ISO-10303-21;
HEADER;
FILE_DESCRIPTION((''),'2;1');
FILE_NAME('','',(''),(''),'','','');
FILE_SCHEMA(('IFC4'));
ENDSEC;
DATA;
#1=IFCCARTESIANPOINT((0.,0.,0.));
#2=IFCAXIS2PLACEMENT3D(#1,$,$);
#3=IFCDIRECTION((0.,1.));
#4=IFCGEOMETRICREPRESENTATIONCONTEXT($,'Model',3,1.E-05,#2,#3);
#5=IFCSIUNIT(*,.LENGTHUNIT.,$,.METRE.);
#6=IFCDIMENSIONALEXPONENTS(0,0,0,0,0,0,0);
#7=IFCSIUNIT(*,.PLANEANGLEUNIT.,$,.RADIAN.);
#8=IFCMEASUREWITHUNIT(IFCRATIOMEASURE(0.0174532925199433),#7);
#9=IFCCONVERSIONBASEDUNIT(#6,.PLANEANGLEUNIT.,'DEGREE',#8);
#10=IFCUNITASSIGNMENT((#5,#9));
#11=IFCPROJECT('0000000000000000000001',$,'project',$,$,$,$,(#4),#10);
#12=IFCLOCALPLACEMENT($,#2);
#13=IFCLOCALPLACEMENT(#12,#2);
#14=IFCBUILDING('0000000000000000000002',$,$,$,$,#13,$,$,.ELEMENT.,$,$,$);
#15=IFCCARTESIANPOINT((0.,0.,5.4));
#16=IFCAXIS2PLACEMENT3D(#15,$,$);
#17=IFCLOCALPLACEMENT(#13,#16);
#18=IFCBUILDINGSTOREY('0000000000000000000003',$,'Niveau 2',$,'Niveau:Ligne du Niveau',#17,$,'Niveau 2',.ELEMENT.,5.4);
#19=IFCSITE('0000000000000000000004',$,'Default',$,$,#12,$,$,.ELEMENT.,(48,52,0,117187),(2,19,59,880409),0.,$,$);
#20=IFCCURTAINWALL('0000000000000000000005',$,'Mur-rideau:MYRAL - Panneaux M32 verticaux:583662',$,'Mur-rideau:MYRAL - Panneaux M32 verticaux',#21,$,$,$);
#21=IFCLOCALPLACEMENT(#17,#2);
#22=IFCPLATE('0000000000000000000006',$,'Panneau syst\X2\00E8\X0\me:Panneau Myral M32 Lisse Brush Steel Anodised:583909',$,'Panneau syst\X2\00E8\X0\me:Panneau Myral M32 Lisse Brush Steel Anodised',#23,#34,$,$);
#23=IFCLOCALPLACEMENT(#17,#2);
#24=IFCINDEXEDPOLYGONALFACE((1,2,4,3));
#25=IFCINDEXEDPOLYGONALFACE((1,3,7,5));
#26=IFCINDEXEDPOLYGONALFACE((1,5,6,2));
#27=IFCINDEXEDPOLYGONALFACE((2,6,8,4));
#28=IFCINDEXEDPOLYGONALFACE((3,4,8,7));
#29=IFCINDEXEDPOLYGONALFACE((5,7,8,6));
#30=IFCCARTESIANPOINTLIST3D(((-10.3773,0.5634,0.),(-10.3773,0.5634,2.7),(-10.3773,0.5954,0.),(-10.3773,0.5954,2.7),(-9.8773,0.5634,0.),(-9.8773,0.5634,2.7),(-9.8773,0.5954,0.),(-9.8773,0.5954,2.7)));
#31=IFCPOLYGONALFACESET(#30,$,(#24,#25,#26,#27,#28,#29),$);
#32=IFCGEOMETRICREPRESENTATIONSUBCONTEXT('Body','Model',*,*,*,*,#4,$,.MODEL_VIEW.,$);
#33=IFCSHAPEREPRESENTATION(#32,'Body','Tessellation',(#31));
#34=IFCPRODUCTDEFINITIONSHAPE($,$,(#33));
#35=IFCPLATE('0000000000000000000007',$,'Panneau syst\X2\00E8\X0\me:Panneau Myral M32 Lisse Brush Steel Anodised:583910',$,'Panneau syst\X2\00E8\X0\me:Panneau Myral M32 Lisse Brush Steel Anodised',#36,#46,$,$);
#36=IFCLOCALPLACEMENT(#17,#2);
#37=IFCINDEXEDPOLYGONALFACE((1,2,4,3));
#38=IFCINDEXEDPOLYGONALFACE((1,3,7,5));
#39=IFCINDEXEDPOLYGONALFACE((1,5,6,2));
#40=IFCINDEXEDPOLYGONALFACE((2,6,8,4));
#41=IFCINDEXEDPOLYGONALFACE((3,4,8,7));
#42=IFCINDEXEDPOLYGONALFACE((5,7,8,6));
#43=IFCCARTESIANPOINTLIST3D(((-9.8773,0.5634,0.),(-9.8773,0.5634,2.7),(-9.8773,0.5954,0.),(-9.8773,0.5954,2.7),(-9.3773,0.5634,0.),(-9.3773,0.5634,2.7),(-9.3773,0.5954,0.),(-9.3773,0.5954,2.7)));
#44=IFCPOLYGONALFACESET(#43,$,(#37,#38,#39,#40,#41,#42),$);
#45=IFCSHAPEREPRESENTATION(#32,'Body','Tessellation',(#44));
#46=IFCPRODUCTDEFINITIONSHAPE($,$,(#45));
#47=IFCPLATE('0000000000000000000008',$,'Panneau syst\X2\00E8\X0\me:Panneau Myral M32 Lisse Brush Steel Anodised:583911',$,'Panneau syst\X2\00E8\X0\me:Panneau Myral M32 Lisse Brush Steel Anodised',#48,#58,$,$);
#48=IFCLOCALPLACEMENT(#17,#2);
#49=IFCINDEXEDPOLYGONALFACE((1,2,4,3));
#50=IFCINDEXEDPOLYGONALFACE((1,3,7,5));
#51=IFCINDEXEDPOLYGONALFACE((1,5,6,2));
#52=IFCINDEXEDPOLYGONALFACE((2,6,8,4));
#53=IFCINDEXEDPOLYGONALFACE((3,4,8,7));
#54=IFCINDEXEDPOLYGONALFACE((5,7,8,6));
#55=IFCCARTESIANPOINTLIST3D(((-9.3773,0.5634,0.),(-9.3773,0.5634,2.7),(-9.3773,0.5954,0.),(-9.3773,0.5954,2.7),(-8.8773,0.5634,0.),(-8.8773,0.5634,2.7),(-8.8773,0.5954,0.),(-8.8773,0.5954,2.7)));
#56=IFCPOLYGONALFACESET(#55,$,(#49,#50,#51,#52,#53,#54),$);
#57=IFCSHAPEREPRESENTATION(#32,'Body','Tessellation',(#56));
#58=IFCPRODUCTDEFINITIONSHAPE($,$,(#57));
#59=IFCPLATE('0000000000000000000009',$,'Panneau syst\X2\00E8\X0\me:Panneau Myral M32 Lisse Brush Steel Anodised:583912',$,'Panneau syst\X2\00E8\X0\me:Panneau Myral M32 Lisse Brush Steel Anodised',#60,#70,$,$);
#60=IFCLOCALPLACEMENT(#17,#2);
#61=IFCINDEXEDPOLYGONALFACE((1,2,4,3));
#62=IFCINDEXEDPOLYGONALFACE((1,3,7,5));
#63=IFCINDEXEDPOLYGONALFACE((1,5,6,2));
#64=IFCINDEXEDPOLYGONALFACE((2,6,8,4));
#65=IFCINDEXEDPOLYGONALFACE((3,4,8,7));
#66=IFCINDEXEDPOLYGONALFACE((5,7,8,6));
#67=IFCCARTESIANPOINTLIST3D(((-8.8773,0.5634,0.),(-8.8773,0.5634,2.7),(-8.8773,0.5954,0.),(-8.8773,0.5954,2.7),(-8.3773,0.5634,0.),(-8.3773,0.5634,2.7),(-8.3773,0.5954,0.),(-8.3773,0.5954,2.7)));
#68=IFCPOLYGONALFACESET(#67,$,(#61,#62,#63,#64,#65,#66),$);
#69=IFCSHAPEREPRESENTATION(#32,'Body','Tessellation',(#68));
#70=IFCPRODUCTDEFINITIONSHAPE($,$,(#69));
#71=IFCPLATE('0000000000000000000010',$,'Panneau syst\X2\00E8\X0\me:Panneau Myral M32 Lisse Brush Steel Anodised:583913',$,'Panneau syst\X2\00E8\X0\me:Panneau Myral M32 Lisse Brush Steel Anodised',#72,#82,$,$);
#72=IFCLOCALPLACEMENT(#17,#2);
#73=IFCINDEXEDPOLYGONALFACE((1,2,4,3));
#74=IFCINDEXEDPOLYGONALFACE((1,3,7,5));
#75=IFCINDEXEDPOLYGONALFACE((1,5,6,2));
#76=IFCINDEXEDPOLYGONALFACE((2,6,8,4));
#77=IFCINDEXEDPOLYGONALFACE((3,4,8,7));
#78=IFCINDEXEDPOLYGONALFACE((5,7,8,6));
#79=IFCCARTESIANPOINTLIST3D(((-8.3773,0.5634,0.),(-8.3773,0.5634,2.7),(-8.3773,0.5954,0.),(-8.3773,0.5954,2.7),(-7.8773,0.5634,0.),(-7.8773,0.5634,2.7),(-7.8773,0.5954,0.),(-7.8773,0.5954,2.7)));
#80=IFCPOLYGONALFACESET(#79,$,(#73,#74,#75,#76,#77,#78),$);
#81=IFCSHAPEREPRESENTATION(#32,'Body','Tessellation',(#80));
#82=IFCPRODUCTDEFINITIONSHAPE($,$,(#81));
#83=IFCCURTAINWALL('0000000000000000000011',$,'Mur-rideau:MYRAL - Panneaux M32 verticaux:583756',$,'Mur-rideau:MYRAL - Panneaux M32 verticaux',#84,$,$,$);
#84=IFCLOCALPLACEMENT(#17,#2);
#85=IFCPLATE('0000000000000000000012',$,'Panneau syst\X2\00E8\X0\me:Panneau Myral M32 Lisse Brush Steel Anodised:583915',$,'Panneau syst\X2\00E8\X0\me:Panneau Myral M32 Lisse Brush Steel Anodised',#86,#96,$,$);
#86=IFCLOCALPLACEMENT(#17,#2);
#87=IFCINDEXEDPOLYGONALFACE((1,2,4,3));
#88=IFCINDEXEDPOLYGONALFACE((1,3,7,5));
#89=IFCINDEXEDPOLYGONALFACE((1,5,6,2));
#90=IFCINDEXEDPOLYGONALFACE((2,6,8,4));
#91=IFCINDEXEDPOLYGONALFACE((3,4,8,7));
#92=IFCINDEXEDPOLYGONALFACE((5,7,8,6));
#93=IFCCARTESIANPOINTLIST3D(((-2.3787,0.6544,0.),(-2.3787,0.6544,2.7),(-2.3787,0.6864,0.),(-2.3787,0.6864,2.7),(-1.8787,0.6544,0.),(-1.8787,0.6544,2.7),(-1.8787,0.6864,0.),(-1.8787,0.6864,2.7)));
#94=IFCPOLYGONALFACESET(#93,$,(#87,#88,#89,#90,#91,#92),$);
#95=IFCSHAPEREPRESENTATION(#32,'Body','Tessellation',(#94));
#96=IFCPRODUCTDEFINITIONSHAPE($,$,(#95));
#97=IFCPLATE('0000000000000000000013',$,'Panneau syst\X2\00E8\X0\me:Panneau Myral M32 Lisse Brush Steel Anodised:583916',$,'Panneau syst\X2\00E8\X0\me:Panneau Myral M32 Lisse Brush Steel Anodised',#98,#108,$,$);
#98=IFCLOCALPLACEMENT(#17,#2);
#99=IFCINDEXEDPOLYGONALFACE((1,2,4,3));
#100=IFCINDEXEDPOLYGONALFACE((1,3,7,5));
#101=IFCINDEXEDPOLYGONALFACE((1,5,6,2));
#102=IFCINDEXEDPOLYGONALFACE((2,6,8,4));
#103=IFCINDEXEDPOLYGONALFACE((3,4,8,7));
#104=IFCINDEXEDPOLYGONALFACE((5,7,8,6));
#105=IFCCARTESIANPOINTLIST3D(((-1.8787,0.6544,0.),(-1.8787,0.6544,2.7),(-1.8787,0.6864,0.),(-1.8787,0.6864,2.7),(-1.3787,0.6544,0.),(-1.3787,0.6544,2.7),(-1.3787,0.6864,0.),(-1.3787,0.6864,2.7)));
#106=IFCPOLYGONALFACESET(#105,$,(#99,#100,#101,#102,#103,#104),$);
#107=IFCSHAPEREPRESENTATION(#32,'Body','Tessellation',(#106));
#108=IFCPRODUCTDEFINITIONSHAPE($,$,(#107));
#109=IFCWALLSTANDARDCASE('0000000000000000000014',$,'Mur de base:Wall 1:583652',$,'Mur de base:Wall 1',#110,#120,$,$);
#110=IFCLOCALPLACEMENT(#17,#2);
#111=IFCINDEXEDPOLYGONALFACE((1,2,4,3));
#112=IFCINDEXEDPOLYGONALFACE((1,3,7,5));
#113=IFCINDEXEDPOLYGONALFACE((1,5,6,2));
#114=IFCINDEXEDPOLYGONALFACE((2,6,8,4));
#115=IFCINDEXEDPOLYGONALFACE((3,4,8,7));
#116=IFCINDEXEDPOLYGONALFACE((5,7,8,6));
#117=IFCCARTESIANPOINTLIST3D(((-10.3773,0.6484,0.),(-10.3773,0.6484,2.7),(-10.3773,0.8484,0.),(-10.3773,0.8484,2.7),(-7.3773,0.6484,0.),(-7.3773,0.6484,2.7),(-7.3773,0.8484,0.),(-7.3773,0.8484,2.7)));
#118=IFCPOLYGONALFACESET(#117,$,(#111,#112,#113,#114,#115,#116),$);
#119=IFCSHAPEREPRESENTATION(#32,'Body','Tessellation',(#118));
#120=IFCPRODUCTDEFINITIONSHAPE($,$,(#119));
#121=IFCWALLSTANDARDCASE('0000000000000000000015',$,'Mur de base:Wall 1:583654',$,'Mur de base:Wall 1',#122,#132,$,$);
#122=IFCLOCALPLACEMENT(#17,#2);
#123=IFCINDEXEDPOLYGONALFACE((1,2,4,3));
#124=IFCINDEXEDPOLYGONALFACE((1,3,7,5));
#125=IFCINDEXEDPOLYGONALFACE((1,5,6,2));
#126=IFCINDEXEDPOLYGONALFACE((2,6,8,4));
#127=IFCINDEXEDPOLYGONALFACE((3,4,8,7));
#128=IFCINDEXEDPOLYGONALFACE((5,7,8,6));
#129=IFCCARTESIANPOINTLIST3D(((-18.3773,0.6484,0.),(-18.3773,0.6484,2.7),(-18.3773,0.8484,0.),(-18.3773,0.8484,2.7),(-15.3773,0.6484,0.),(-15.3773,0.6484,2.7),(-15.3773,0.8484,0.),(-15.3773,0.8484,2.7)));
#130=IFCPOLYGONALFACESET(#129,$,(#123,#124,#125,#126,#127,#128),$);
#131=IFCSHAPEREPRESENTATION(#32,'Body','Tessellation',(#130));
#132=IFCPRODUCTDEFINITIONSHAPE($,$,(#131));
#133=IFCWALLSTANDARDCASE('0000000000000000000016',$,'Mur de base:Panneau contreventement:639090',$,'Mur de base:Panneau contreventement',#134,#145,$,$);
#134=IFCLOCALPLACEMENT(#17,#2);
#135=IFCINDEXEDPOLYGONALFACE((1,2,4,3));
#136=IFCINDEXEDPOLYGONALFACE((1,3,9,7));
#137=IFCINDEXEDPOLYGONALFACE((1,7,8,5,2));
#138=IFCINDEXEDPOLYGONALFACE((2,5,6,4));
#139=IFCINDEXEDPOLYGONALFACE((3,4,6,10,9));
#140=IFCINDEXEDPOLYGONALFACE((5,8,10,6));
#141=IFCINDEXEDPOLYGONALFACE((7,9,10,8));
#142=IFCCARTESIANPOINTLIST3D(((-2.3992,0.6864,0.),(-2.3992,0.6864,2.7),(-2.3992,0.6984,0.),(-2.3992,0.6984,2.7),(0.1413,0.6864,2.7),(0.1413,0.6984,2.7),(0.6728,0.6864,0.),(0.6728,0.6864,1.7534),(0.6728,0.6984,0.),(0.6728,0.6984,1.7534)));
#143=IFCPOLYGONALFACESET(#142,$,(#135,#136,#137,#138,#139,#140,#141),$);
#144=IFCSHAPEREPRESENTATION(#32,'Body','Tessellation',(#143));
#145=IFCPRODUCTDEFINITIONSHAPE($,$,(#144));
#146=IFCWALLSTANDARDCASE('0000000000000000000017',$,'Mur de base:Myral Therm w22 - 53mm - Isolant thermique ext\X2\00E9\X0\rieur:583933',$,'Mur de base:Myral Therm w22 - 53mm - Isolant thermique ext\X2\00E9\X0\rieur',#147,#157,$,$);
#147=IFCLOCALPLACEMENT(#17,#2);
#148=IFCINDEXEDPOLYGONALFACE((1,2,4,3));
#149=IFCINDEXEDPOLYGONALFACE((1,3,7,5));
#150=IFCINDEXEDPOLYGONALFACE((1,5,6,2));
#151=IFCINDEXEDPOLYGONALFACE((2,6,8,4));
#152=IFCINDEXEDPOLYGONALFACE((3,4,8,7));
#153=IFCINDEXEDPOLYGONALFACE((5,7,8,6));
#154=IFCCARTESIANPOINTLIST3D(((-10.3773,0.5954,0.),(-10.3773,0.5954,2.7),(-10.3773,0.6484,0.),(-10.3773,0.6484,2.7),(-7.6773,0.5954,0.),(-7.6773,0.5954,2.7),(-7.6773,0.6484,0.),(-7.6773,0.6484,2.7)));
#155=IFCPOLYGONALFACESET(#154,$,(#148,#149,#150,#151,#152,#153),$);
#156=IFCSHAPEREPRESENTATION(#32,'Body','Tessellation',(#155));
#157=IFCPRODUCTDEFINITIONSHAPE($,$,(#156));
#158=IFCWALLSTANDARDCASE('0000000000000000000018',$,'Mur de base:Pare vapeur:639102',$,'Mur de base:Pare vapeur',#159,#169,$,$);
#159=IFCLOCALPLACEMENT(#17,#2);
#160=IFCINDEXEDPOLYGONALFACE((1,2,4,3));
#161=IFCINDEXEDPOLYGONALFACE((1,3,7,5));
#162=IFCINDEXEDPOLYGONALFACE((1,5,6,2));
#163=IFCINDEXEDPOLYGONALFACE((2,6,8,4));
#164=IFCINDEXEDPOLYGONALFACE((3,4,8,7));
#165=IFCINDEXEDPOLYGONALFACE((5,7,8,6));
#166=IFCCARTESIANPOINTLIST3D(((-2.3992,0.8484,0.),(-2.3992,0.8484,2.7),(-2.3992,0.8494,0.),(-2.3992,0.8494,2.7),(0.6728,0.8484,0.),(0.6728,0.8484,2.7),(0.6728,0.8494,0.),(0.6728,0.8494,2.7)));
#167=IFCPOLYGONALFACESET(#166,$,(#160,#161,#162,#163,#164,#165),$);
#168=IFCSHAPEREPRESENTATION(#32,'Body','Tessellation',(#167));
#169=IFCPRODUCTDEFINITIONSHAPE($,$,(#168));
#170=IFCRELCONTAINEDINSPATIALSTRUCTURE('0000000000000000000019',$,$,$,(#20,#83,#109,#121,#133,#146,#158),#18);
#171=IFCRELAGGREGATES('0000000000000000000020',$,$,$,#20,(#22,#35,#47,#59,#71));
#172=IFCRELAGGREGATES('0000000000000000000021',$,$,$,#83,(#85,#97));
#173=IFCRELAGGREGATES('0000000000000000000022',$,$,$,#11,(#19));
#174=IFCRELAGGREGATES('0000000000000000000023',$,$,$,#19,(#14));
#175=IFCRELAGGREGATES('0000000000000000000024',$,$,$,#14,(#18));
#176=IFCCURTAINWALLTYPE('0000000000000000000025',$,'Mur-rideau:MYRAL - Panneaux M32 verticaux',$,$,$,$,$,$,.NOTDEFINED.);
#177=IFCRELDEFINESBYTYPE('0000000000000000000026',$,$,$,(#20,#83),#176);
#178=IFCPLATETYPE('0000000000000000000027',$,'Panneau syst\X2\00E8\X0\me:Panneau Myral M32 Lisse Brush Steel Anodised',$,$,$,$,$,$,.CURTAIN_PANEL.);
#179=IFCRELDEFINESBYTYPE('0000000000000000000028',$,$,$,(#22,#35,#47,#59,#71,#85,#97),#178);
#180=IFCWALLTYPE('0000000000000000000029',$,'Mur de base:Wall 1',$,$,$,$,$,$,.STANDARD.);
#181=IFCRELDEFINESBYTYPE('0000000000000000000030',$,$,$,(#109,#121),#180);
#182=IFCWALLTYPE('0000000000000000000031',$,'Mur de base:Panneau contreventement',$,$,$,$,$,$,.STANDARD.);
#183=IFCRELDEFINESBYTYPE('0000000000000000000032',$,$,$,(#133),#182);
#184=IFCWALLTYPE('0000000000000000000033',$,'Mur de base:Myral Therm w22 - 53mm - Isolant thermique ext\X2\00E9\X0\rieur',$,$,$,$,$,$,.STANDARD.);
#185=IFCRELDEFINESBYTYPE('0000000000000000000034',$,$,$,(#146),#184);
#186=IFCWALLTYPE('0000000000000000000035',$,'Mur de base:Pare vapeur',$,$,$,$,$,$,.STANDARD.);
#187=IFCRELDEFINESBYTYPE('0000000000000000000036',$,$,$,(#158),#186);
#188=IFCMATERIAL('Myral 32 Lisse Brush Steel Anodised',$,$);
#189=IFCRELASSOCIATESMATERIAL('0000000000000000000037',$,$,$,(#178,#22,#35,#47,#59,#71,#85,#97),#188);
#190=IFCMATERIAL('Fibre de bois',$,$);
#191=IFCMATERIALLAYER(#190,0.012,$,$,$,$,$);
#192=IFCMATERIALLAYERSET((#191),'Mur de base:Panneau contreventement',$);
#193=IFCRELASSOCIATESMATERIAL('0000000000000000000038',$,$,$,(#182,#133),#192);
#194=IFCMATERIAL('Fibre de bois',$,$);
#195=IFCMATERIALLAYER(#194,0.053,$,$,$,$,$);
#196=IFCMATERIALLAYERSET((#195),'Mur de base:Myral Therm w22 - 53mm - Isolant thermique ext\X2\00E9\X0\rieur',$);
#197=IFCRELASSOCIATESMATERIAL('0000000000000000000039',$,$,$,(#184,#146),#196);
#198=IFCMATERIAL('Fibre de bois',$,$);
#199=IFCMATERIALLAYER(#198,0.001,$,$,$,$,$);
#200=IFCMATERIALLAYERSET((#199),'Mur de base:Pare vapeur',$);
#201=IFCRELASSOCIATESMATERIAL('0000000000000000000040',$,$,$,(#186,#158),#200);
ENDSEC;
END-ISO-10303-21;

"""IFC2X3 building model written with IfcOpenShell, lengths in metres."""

from ifc_helpers import new_model, entity, si_unit, converted_unit, direction, frame, frame_2d, origin, origin_2d_with_axis, place, context, subcontext, project, spatial, rectangle, extrude, clip, halfspace, source, transform, mapped, material, layer, layer_set, layer_usage, type_object, type_shapes, element, aggregate, save


model = new_model("IFC2X3")

# Units and contexts
model_context = context("Model", 3, precision=1e-05, world=origin(), true_north=direction((0.0, 1.0)))
body_context = subcontext(model_context, "Body", "Model", "MODEL_VIEW")
ifc_project = project(units=[si_unit("LENGTHUNIT", "METRE"), converted_unit("PLANEANGLEUNIT", "DEGREE", entity("IfcRatioMeasure", 0.0174532925199433), si_unit("PLANEANGLEUNIT", "RADIAN"), dimensions=[0, 0, 0, 0, 0, 0, 0])], contexts=[model_context])

# Site, building, storey
site_placement = place(None, origin())
site = spatial("IfcSite", under=ifc_project, at=site_placement, Name="Default", CompositionType="ELEMENT", RefLatitude=(48, 52, 0, 117187), RefLongitude=(2, 19, 59, 880409), RefElevation=0.0)
building_placement = place(site_placement, origin())
building = spatial("IfcBuilding", under=site, at=building_placement, CompositionType="ELEMENT")
storey_placement = place(building_placement, frame((0.0, 0.0, 5.4)))
storey = spatial("IfcBuildingStorey", under=building, at=storey_placement, Name="Niveau 2", ObjectType="Niveau:Ligne du Niveau", LongName="Niveau 2", CompositionType="ELEMENT", Elevation=5.4)

# Shared definitions
ifc_material_1 = material(Name="Fibre de bois")

# Curtain walls, plates
curtain_wall_type_1 = type_object("IfcCurtainWallType", Name="Mur-rideau:MYRAL - Panneaux M32 verticaux", PredefinedType="NOTDEFINED")
ifc_material_2 = material(Name="Myral 32 Lisse Brush Steel Anodised")
plate_type = type_object("IfcPlateType", Name="Panneau système:Panneau Myral M32 Lisse Brush Steel Anodised", PredefinedType="CURTAIN_PANEL", material=ifc_material_2)
shared_shape_1 = source(origin(), body_context, "Body", "SweptSolid", [
    extrude(rectangle(XDim=0.032, YDim=0.5, at=origin_2d_with_axis()), frame((0.0, -0.016, 0.0), z_axis=(0.0, 0.0, 1.0), x_axis=(0.0, 1.0, 0.0)), (0.0, 0.0, 1.0), 2.7),
])
type_shapes(plate_type, [shared_shape_1])
curtain_wall_1_placement = place(storey_placement, frame((0.0, 0.0, -5.4)))
curtain_wall_1 = element("IfcCurtainWall", 1, at=curtain_wall_1_placement, inside=storey, type_object=curtain_wall_type_1, Name="Mur-rideau:MYRAL - Panneaux M32 verticaux:583662", ObjectType="Mur-rideau:MYRAL - Panneaux M32 verticaux")
plate_1_placement = place(curtain_wall_1_placement, frame((-10.1273, 0.5954, 5.4)))
plate_1 = element("IfcPlate", 2, at=plate_1_placement, type_object=plate_type, material=ifc_material_2, Name="Panneau système:Panneau Myral M32 Lisse Brush Steel Anodised:583909", ObjectType="Panneau système:Panneau Myral M32 Lisse Brush Steel Anodised", context=body_context, shape_type="MappedRepresentation", body=[
    mapped(shared_shape_1, transform((0.0, 0.0, 0.0), scale=1.0)),
])
plate_2_placement = place(curtain_wall_1_placement, frame((-9.6273, 0.5954, 5.4)))
plate_2 = element("IfcPlate", 3, at=plate_2_placement, type_object=plate_type, material=ifc_material_2, Name="Panneau système:Panneau Myral M32 Lisse Brush Steel Anodised:583910", ObjectType="Panneau système:Panneau Myral M32 Lisse Brush Steel Anodised", context=body_context, shape_type="MappedRepresentation", body=[
    mapped(shared_shape_1, transform((0.0, 0.0, 0.0), scale=1.0)),
])
plate_3_placement = place(curtain_wall_1_placement, frame((-9.1273, 0.5954, 5.4)))
plate_3 = element("IfcPlate", 4, at=plate_3_placement, type_object=plate_type, material=ifc_material_2, Name="Panneau système:Panneau Myral M32 Lisse Brush Steel Anodised:583911", ObjectType="Panneau système:Panneau Myral M32 Lisse Brush Steel Anodised", context=body_context, shape_type="MappedRepresentation", body=[
    mapped(shared_shape_1, transform((0.0, 0.0, 0.0), scale=1.0)),
])
plate_4_placement = place(curtain_wall_1_placement, frame((-8.6273, 0.5954, 5.4)))
plate_4 = element("IfcPlate", 5, at=plate_4_placement, type_object=plate_type, material=ifc_material_2, Name="Panneau système:Panneau Myral M32 Lisse Brush Steel Anodised:583912", ObjectType="Panneau système:Panneau Myral M32 Lisse Brush Steel Anodised", context=body_context, shape_type="MappedRepresentation", body=[
    mapped(shared_shape_1, transform((0.0, 0.0, 0.0), scale=1.0)),
])
plate_5_placement = place(curtain_wall_1_placement, frame((-8.1273, 0.5954, 5.4)))
plate_5 = element("IfcPlate", 6, at=plate_5_placement, type_object=plate_type, material=ifc_material_2, Name="Panneau système:Panneau Myral M32 Lisse Brush Steel Anodised:583913", ObjectType="Panneau système:Panneau Myral M32 Lisse Brush Steel Anodised", context=body_context, shape_type="MappedRepresentation", body=[
    mapped(shared_shape_1, transform((0.0, 0.0, 0.0), scale=1.0)),
])
aggregate(curtain_wall_1, [plate_1, plate_2, plate_3, plate_4, plate_5])
curtain_wall_2_placement = place(storey_placement, frame((0.0, 0.0, -5.4)))
curtain_wall_2 = element("IfcCurtainWall", 7, at=curtain_wall_2_placement, inside=storey, type_object=curtain_wall_type_1, Name="Mur-rideau:MYRAL - Panneaux M32 verticaux:583756", ObjectType="Mur-rideau:MYRAL - Panneaux M32 verticaux")
plate_6_placement = place(curtain_wall_2_placement, frame((-2.1287, 0.6864, 5.4)))
plate_6 = element("IfcPlate", 8, at=plate_6_placement, type_object=plate_type, material=ifc_material_2, Name="Panneau système:Panneau Myral M32 Lisse Brush Steel Anodised:583915", ObjectType="Panneau système:Panneau Myral M32 Lisse Brush Steel Anodised", context=body_context, shape_type="MappedRepresentation", body=[
    mapped(shared_shape_1, transform((0.0, 0.0, 0.0), scale=1.0)),
])
plate_7_placement = place(curtain_wall_2_placement, frame((-1.6287, 0.6864, 5.4)))
plate_7 = element("IfcPlate", 9, at=plate_7_placement, type_object=plate_type, material=ifc_material_2, Name="Panneau système:Panneau Myral M32 Lisse Brush Steel Anodised:583916", ObjectType="Panneau système:Panneau Myral M32 Lisse Brush Steel Anodised", context=body_context, shape_type="MappedRepresentation", body=[
    mapped(shared_shape_1, transform((0.0, 0.0, 0.0), scale=1.0)),
])
aggregate(curtain_wall_2, [plate_6, plate_7])

# Walls
wall_type_1 = type_object("IfcWallType", Name="Mur de base:Wall 1", PredefinedType="STANDARD")
for number, where, name in (
    (10, (-10.3773, 0.7484, 0.0), "Mur de base:Wall 1:583652"),
    (11, (-18.3773, 0.7484, 0.0), "Mur de base:Wall 1:583654"),
):
    element("IfcWallStandardCase", number, at=place(storey_placement, frame(where)), inside=storey, type_object=wall_type_1, Name=name, ObjectType="Mur de base:Wall 1", context=body_context, shape_type="SweptSolid", body=[
        extrude(rectangle(XDim=3.0, YDim=0.2, at=frame_2d((1.5, 0.0), x_axis=(-1.0, 0.0))), origin(), (0.0, 0.0, 1.0), 2.7),
    ])
ifc_layer_1 = layer(ifc_material_1, 0.012)
ifc_layer_set_1 = layer_set([ifc_layer_1], Name="Mur de base:Panneau contreventement")
ifc_layer_usage_1 = layer_usage(ifc_layer_set_1, "AXIS2", "NEGATIVE", 0.006)
wall_type_2 = type_object("IfcWallType", Name="Mur de base:Panneau contreventement", PredefinedType="STANDARD", material=ifc_layer_set_1)
wall_1_placement = place(storey_placement, frame((-2.3992, 0.6924, 0.0)))
element("IfcWallStandardCase", 12, at=wall_1_placement, inside=storey, type_object=wall_type_2, material=ifc_layer_usage_1, Name="Mur de base:Panneau contreventement:639090", ObjectType="Mur de base:Panneau contreventement", context=body_context, shape_type="Clipping", body=[
    clip(extrude(rectangle(XDim=3.072, YDim=0.012, at=frame_2d((1.536, 0.0), x_axis=(-1.0, 0.0))), origin(), (0.0, 0.0, 1.0), 2.7), halfspace(frame((2.5405, -0.006, 2.7), z_axis=(0.871952, 0.0, 0.489592), x_axis=(0.0, 1.0, 0.0)), False)),
])
ifc_material_3 = material(Name="Fibre de bois")
ifc_layer_2 = layer(ifc_material_3, 0.053)
ifc_layer_set_2 = layer_set([ifc_layer_2], Name="Mur de base:Myral Therm w22 - 53mm - Isolant thermique extérieur")
ifc_layer_usage_2 = layer_usage(ifc_layer_set_2, "AXIS2", "NEGATIVE", 0.0265)
wall_type_3 = type_object("IfcWallType", Name="Mur de base:Myral Therm w22 - 53mm - Isolant thermique extérieur", PredefinedType="STANDARD", material=ifc_layer_set_2)
wall_2_placement = place(storey_placement, frame((-10.3773, 0.6219, 0.0)))
element("IfcWallStandardCase", 13, at=wall_2_placement, inside=storey, type_object=wall_type_3, material=ifc_layer_usage_2, Name="Mur de base:Myral Therm w22 - 53mm - Isolant thermique extérieur:583933", ObjectType="Mur de base:Myral Therm w22 - 53mm - Isolant thermique extérieur", context=body_context, shape_type="SweptSolid", body=[
    extrude(rectangle(XDim=2.7, YDim=0.053, at=frame_2d((1.35, 0.0), x_axis=(-1.0, 0.0))), origin(), (0.0, 0.0, 1.0), 2.7),
])
ifc_material_4 = material(Name="Fibre de bois")
ifc_layer_3 = layer(ifc_material_4, 0.001)
ifc_layer_set_3 = layer_set([ifc_layer_3], Name="Mur de base:Pare vapeur")
ifc_layer_usage_3 = layer_usage(ifc_layer_set_3, "AXIS2", "NEGATIVE", 0.0005)
wall_type_4 = type_object("IfcWallType", Name="Mur de base:Pare vapeur", PredefinedType="STANDARD", material=ifc_layer_set_3)
wall_3_placement = place(storey_placement, frame((-2.3992, 0.8489, 0.0)))
element("IfcWallStandardCase", 14, at=wall_3_placement, inside=storey, type_object=wall_type_4, material=ifc_layer_usage_3, Name="Mur de base:Pare vapeur:639102", ObjectType="Mur de base:Pare vapeur", context=body_context, shape_type="SweptSolid", body=[
    extrude(rectangle(XDim=3.072, YDim=0.001, at=frame_2d((1.536, 0.0), x_axis=(-1.0, 0.0))), origin(), (0.0, 0.0, 1.0), 2.7),
])

save(model, "model.ifc")
